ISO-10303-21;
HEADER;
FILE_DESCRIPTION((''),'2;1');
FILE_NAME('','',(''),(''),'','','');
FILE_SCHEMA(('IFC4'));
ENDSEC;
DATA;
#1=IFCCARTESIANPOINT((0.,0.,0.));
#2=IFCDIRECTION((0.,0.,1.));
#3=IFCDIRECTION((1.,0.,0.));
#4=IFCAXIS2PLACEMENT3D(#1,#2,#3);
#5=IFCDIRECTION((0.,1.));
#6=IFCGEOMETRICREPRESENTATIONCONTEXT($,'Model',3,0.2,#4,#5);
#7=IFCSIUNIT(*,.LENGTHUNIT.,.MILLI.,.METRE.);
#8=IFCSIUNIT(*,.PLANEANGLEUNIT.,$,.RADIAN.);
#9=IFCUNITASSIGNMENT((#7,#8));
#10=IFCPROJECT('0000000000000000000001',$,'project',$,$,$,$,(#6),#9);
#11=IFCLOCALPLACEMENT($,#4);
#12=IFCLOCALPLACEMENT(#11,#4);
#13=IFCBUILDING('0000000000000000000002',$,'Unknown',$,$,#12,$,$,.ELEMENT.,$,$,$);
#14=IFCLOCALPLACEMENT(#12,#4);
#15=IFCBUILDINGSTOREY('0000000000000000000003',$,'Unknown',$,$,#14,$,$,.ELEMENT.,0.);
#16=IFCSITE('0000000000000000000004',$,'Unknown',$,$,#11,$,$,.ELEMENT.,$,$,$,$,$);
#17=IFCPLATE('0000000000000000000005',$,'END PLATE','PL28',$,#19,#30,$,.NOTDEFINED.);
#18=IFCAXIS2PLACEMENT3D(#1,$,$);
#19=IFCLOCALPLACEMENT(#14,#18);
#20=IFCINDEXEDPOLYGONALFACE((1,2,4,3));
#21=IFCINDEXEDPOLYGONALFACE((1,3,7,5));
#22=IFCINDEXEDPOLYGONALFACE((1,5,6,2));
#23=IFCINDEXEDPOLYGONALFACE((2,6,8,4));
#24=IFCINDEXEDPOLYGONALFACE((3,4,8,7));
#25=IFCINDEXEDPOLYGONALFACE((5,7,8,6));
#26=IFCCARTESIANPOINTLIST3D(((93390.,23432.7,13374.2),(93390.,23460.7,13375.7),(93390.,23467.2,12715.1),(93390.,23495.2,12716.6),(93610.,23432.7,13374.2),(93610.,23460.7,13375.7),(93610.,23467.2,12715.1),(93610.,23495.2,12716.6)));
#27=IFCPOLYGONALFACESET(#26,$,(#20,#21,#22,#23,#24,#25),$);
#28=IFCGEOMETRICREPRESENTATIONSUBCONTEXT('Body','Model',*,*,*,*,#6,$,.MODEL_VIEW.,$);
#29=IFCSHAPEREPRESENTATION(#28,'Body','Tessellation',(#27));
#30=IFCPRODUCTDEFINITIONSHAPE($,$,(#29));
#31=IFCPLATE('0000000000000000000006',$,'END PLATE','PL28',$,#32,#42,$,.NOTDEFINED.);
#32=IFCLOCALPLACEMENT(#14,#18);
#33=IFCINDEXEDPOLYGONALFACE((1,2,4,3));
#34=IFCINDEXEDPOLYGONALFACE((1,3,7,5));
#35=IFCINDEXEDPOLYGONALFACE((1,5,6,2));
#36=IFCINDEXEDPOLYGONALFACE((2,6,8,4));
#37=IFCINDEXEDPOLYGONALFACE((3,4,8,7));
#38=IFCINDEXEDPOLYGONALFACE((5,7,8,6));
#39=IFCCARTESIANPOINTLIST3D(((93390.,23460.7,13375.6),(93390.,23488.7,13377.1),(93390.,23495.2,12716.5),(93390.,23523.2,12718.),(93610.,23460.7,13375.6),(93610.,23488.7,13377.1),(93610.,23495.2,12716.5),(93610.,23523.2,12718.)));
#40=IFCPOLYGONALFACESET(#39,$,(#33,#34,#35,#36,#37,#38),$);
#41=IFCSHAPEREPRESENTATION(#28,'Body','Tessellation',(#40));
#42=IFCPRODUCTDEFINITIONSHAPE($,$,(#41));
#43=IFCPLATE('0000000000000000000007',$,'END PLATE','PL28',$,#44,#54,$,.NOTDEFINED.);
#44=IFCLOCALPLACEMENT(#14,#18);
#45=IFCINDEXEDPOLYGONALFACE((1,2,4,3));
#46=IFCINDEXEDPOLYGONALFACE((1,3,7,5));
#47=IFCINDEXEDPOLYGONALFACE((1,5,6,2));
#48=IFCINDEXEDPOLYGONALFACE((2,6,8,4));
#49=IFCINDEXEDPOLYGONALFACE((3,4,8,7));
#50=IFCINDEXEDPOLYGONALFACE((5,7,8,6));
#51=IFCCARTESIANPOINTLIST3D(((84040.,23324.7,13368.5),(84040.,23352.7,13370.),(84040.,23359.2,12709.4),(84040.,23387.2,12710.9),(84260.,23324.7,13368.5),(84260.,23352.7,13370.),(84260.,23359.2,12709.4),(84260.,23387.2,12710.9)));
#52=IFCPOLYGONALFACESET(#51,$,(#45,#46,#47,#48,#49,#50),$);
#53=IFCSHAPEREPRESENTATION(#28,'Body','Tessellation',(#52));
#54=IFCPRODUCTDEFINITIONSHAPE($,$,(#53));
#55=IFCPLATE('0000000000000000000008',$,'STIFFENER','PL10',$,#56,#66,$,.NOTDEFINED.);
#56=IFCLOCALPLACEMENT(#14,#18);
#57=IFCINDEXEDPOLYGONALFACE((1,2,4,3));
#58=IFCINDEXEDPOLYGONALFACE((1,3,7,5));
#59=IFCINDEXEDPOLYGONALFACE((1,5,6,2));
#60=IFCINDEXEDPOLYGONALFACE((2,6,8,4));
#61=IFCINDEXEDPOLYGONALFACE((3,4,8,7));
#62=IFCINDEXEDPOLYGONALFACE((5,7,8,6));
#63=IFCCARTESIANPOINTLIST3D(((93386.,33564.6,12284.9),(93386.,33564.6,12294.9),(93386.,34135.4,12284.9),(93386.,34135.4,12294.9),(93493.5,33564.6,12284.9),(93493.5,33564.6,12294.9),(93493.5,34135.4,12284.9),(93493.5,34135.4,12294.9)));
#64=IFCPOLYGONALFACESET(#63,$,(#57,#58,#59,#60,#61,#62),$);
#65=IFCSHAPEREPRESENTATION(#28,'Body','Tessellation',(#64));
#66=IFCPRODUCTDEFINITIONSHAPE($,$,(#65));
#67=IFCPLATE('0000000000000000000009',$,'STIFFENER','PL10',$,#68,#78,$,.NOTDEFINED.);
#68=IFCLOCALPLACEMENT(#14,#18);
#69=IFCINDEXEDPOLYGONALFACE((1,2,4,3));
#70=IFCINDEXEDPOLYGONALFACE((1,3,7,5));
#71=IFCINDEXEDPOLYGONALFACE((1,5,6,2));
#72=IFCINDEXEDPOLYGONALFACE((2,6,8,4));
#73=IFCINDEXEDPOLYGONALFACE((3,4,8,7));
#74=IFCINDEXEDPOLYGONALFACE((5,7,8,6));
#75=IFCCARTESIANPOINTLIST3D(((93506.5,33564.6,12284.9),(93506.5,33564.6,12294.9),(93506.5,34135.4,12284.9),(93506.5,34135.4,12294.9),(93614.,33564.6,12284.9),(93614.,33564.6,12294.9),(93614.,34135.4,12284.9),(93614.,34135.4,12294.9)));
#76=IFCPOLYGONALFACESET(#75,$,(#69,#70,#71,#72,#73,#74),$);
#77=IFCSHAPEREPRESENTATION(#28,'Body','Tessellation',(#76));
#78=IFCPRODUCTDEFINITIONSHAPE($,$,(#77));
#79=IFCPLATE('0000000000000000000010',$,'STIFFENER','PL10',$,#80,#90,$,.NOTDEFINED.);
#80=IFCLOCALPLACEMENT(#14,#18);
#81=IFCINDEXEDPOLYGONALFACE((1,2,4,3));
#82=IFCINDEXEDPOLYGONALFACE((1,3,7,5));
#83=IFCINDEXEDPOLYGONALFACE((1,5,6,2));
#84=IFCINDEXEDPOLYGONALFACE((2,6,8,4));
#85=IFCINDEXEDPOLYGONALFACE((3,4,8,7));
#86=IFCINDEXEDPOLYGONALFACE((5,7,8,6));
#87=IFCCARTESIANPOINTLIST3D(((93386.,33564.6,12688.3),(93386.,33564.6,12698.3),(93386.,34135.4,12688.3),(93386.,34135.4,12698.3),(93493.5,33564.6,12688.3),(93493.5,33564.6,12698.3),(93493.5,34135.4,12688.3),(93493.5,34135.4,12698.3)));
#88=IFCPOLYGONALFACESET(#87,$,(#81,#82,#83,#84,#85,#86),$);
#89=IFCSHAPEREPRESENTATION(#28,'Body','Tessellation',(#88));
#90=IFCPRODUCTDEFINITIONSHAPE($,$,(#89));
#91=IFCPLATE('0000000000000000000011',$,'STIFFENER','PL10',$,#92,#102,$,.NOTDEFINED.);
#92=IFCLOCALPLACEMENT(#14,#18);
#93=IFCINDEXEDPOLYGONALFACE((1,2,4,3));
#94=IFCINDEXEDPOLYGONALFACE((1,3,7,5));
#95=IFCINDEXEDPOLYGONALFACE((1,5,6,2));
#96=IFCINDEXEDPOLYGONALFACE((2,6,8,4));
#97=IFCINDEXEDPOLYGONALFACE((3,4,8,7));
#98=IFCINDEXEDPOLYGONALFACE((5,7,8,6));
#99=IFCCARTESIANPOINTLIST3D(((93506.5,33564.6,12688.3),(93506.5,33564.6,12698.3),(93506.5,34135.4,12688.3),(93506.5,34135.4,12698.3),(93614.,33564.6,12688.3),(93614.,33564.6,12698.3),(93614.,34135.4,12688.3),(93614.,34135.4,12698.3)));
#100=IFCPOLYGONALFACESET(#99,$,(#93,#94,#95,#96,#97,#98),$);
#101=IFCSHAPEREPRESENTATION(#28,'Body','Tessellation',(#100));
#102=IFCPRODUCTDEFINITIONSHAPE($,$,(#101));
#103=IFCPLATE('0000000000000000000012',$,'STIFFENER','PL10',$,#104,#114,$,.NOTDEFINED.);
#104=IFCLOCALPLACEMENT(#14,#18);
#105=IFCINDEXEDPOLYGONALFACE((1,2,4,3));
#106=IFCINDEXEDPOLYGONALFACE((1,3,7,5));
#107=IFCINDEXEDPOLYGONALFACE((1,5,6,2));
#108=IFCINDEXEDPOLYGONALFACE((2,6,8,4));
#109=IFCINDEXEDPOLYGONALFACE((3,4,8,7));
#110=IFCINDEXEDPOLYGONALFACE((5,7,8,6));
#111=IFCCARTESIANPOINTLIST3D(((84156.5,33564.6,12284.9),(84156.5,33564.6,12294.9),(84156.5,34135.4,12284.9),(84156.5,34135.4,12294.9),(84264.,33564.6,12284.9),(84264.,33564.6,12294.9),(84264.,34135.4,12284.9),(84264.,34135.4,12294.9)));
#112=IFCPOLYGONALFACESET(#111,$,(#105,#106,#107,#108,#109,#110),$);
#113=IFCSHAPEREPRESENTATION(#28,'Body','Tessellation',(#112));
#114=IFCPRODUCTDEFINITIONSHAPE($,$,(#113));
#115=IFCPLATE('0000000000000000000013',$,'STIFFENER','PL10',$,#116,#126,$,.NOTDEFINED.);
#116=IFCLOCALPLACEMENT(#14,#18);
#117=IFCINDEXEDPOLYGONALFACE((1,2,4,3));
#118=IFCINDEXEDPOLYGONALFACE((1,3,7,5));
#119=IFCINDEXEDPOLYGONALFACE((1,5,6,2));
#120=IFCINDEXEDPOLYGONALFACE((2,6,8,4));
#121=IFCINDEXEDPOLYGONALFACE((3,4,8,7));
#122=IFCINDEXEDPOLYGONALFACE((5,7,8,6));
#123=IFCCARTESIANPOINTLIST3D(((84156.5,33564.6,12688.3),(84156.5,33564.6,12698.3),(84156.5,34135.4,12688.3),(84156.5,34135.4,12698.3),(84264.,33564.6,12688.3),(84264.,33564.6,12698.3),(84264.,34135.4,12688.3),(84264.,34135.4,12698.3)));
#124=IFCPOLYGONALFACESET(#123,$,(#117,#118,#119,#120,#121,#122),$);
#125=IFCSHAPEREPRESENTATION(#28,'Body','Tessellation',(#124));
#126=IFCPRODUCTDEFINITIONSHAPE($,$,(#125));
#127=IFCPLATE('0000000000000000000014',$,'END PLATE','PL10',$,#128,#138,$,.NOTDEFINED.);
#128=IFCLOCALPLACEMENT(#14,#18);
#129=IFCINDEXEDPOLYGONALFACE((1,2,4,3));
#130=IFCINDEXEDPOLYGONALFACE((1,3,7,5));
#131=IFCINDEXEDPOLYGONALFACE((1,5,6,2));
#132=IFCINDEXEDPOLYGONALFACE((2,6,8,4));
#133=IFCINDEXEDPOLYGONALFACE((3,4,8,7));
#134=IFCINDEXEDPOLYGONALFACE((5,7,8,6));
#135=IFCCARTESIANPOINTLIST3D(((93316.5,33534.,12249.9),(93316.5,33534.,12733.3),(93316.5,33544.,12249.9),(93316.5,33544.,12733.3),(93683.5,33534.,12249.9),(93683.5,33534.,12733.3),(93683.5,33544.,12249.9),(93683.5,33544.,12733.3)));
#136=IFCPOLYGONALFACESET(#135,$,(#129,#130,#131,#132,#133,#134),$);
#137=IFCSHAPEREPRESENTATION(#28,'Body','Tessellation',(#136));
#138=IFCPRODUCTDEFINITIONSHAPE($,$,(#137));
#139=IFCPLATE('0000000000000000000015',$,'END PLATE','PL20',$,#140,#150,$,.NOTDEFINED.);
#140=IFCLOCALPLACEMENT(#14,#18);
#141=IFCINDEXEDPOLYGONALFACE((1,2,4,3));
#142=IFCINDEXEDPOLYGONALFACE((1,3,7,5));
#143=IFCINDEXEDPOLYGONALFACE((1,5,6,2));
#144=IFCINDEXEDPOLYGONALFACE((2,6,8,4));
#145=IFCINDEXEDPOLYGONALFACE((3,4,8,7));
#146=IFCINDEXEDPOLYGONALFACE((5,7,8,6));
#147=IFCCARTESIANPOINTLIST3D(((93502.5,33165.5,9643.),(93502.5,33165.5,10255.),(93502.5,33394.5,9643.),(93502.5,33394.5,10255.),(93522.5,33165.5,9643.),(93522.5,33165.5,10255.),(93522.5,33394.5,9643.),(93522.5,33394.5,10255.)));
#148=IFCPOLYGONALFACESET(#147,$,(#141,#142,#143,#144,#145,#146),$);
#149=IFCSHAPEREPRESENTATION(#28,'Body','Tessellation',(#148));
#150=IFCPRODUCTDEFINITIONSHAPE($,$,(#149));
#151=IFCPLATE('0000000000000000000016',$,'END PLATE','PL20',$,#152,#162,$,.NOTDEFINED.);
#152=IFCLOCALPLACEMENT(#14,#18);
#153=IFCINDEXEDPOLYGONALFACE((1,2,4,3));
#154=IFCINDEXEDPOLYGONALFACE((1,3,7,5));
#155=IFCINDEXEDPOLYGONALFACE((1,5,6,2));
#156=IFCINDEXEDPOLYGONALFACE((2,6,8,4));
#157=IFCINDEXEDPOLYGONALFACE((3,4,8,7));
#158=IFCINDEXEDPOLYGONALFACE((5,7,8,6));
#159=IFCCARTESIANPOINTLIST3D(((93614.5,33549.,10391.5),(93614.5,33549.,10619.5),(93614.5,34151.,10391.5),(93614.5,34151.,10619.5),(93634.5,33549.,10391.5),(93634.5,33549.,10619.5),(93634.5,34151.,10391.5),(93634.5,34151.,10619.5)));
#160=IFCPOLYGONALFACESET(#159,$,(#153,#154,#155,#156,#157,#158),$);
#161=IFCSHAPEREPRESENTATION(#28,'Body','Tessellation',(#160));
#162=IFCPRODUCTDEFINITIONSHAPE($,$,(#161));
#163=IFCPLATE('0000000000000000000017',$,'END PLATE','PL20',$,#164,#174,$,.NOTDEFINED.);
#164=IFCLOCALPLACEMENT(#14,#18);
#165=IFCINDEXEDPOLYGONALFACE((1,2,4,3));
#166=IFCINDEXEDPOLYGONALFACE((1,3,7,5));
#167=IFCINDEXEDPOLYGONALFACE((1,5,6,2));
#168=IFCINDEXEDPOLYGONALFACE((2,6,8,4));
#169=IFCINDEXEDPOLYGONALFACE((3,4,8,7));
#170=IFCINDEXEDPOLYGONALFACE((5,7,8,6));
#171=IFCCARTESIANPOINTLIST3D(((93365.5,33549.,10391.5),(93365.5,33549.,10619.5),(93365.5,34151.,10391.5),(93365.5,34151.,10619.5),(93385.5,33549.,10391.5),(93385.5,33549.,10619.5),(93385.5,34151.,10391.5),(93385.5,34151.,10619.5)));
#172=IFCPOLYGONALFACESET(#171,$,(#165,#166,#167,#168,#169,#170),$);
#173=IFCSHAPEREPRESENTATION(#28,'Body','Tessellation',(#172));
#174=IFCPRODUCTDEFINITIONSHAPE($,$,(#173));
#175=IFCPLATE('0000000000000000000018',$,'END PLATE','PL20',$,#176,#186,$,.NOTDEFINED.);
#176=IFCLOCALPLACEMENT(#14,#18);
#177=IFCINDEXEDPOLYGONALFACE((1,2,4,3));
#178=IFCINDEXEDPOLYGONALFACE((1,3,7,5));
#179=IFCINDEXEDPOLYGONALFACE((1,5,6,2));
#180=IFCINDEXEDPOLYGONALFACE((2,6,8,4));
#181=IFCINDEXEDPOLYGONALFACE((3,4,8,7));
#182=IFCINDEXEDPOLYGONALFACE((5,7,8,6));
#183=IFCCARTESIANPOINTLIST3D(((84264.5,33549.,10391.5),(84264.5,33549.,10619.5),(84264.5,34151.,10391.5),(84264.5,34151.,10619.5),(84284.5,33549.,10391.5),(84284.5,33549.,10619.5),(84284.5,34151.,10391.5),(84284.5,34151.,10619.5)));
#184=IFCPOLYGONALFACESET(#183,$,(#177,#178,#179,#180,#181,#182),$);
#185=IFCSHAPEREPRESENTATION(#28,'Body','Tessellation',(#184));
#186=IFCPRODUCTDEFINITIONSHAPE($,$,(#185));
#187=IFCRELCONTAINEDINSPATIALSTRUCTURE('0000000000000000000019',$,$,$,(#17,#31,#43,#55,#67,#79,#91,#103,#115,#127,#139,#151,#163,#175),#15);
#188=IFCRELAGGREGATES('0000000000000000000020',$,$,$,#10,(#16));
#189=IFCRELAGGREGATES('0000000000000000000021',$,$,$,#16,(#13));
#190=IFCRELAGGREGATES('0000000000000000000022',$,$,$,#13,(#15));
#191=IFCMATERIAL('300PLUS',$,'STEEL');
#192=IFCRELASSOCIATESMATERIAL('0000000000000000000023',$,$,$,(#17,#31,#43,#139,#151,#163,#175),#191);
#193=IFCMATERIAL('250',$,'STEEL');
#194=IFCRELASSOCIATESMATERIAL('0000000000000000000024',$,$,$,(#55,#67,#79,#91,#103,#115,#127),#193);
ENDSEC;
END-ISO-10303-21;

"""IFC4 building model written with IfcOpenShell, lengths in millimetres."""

from ifc_helpers import new_model, si_unit, direction, frame, origin_with_axes, place, context, subcontext, project, spatial, line, indexed_curve, outline, extrude, material, element, save


model = new_model("IFC4")

# Units and contexts
model_context = context("Model", 3, precision=0.2, world=origin_with_axes(), true_north=direction((0.0, 1.0)))
body_context = subcontext(model_context, "Body", "Model", "MODEL_VIEW")
ifc_project = project(units=[si_unit("LENGTHUNIT", "METRE", prefix="MILLI"), si_unit("PLANEANGLEUNIT", "RADIAN")], contexts=[model_context])

# Site, building, storey
site_placement = place(None, origin_with_axes())
site = spatial("IfcSite", under=ifc_project, at=site_placement, Name="Unknown", CompositionType="ELEMENT")
building_placement = place(site_placement, origin_with_axes())
building = spatial("IfcBuilding", under=site, at=building_placement, Name="Unknown", CompositionType="ELEMENT")
storey_placement = place(building_placement, origin_with_axes())
storey = spatial("IfcBuildingStorey", under=building, at=storey_placement, Name="Unknown", CompositionType="ELEMENT", Elevation=0.0)

# Shared definitions
ifc_material_1 = material(Name="300PLUS", Category="STEEL")

# Plates
for number, where, z_axis, x_axis, name in (
    (1, (93610.0, 23481.2, 12715.8), (0.0, 0.998633, 0.052273), (-1.0, 0.0, 0.0), "END PLATE"),
    (2, (93610.0, 23509.2, 12717.2), (0.0, 0.998633, 0.052273), (-1.0, 0.0, 0.0), "END PLATE"),
    (3, (84260.0, 23373.2, 12710.1), (0.0, 0.998633, 0.052273), (-1.0, 0.0, 0.0), "END PLATE"),
):
    element("IfcPlate", number, at=place(storey_placement, frame(where, z_axis=z_axis, x_axis=x_axis)), inside=storey, material=ifc_material_1, Name=name, Description="PL28", PredefinedType="NOTDEFINED", context=body_context, shape_type="SolidModel", body=[
        extrude(outline(indexed_curve([(0.0, 0.0), (220.0, 0.0), (220.0, 660.0), (0.0, 660.0)], segments=[line(1, 2, 3, 4, 1)])), frame((0.0, 0.0, 14.0), z_axis=(0.0, 0.0, 1.0), x_axis=(1.0, 0.0, 0.0)), (0.0, 0.0, -1.0), 28.0),
    ])
ifc_material_2 = material(Name="250", Category="STEEL")
for number, where, z_axis, x_axis, name in (
    (4, (93493.5, 33564.6, 12289.9), (0.0, 0.0, 1.0), (0.0, 1.0, 0.0), "STIFFENER"),
    (5, (93614.0, 33564.6, 12289.9), (0.0, 0.0, 1.0), (0.0, 1.0, 0.0), "STIFFENER"),
    (6, (93493.5, 33564.6, 12693.3), (0.0, 0.0, 1.0), (0.0, 1.0, 0.0), "STIFFENER"),
    (7, (93614.0, 33564.6, 12693.3), (0.0, 0.0, 1.0), (0.0, 1.0, 0.0), "STIFFENER"),
    (8, (84264.0, 33564.6, 12289.9), (0.0, 0.0, 1.0), (0.0, 1.0, 0.0), "STIFFENER"),
    (9, (84264.0, 33564.6, 12693.3), (0.0, 0.0, 1.0), (0.0, 1.0, 0.0), "STIFFENER"),
):
    element("IfcPlate", number, at=place(storey_placement, frame(where, z_axis=z_axis, x_axis=x_axis)), inside=storey, material=ifc_material_2, Name=name, Description="PL10", PredefinedType="NOTDEFINED", context=body_context, shape_type="SolidModel", body=[
        extrude(outline(indexed_curve([(0.0, 0.0), (570.8, 0.0), (570.8, 107.5), (0.0, 107.5)], segments=[line(1, 2, 3, 4, 1)])), frame((0.0, 0.0, 5.0), z_axis=(0.0, 0.0, 1.0), x_axis=(1.0, 0.0, 0.0)), (0.0, 0.0, -1.0), 10.0),
    ])
plate_1_placement = place(storey_placement, frame((93316.5, 33539.0, 12249.9), z_axis=(0.0, -1.0, 0.0), x_axis=(1.0, 0.0, 0.0)))
element("IfcPlate", 10, at=plate_1_placement, inside=storey, material=ifc_material_2, Name="END PLATE", Description="PL10", PredefinedType="NOTDEFINED", context=body_context, shape_type="SolidModel", body=[
    extrude(outline(indexed_curve([(0.0, 0.0), (367.0, 0.0), (367.0, 483.4), (0.0, 483.4)], segments=[line(1, 2, 3, 4, 1)])), frame((0.0, 0.0, 5.0), z_axis=(0.0, 0.0, 1.0), x_axis=(1.0, 0.0, 0.0)), (0.0, 0.0, -1.0), 10.0),
])
plate_2_placement = place(storey_placement, frame((93512.5, 33394.5, 10255.0), z_axis=(1.0, 0.0, 0.0), x_axis=(0.0, -1.0, 0.0)))
element("IfcPlate", 11, at=plate_2_placement, inside=storey, material=ifc_material_1, Name="END PLATE", Description="PL20", PredefinedType="NOTDEFINED", context=body_context, shape_type="SolidModel", body=[
    extrude(outline(indexed_curve([(0.0, 0.0), (229.0, 0.0), (229.0, 612.0), (0.0, 612.0)], segments=[line(1, 2, 3, 4, 1)])), frame((0.0, 0.0, 10.0), z_axis=(0.0, 0.0, 1.0), x_axis=(1.0, 0.0, 0.0)), (0.0, 0.0, -1.0), 20.0),
])
for number, where, z_axis, x_axis, name in (
    (12, (93624.5, 33549.0, 10619.5), (1.0, 0.0, 0.0), (0.0, 0.0, -1.0), "END PLATE"),
    (13, (93375.5, 33549.0, 10391.5), (-1.0, 0.0, 0.0), (0.0, 0.0, 1.0), "END PLATE"),
    (14, (84274.5, 33549.0, 10619.5), (1.0, 0.0, 0.0), (0.0, 0.0, -1.0), "END PLATE"),
):
    element("IfcPlate", number, at=place(storey_placement, frame(where, z_axis=z_axis, x_axis=x_axis)), inside=storey, material=ifc_material_1, Name=name, Description="PL20", PredefinedType="NOTDEFINED", context=body_context, shape_type="SolidModel", body=[
        extrude(outline(indexed_curve([(0.0, 0.0), (228.0, 0.0), (228.0, 602.0), (0.0, 602.0)], segments=[line(1, 2, 3, 4, 1)])), frame((0.0, 0.0, 10.0), z_axis=(0.0, 0.0, 1.0), x_axis=(1.0, 0.0, 0.0)), (0.0, 0.0, -1.0), 20.0),
    ])

save(model, "model.ifc")
